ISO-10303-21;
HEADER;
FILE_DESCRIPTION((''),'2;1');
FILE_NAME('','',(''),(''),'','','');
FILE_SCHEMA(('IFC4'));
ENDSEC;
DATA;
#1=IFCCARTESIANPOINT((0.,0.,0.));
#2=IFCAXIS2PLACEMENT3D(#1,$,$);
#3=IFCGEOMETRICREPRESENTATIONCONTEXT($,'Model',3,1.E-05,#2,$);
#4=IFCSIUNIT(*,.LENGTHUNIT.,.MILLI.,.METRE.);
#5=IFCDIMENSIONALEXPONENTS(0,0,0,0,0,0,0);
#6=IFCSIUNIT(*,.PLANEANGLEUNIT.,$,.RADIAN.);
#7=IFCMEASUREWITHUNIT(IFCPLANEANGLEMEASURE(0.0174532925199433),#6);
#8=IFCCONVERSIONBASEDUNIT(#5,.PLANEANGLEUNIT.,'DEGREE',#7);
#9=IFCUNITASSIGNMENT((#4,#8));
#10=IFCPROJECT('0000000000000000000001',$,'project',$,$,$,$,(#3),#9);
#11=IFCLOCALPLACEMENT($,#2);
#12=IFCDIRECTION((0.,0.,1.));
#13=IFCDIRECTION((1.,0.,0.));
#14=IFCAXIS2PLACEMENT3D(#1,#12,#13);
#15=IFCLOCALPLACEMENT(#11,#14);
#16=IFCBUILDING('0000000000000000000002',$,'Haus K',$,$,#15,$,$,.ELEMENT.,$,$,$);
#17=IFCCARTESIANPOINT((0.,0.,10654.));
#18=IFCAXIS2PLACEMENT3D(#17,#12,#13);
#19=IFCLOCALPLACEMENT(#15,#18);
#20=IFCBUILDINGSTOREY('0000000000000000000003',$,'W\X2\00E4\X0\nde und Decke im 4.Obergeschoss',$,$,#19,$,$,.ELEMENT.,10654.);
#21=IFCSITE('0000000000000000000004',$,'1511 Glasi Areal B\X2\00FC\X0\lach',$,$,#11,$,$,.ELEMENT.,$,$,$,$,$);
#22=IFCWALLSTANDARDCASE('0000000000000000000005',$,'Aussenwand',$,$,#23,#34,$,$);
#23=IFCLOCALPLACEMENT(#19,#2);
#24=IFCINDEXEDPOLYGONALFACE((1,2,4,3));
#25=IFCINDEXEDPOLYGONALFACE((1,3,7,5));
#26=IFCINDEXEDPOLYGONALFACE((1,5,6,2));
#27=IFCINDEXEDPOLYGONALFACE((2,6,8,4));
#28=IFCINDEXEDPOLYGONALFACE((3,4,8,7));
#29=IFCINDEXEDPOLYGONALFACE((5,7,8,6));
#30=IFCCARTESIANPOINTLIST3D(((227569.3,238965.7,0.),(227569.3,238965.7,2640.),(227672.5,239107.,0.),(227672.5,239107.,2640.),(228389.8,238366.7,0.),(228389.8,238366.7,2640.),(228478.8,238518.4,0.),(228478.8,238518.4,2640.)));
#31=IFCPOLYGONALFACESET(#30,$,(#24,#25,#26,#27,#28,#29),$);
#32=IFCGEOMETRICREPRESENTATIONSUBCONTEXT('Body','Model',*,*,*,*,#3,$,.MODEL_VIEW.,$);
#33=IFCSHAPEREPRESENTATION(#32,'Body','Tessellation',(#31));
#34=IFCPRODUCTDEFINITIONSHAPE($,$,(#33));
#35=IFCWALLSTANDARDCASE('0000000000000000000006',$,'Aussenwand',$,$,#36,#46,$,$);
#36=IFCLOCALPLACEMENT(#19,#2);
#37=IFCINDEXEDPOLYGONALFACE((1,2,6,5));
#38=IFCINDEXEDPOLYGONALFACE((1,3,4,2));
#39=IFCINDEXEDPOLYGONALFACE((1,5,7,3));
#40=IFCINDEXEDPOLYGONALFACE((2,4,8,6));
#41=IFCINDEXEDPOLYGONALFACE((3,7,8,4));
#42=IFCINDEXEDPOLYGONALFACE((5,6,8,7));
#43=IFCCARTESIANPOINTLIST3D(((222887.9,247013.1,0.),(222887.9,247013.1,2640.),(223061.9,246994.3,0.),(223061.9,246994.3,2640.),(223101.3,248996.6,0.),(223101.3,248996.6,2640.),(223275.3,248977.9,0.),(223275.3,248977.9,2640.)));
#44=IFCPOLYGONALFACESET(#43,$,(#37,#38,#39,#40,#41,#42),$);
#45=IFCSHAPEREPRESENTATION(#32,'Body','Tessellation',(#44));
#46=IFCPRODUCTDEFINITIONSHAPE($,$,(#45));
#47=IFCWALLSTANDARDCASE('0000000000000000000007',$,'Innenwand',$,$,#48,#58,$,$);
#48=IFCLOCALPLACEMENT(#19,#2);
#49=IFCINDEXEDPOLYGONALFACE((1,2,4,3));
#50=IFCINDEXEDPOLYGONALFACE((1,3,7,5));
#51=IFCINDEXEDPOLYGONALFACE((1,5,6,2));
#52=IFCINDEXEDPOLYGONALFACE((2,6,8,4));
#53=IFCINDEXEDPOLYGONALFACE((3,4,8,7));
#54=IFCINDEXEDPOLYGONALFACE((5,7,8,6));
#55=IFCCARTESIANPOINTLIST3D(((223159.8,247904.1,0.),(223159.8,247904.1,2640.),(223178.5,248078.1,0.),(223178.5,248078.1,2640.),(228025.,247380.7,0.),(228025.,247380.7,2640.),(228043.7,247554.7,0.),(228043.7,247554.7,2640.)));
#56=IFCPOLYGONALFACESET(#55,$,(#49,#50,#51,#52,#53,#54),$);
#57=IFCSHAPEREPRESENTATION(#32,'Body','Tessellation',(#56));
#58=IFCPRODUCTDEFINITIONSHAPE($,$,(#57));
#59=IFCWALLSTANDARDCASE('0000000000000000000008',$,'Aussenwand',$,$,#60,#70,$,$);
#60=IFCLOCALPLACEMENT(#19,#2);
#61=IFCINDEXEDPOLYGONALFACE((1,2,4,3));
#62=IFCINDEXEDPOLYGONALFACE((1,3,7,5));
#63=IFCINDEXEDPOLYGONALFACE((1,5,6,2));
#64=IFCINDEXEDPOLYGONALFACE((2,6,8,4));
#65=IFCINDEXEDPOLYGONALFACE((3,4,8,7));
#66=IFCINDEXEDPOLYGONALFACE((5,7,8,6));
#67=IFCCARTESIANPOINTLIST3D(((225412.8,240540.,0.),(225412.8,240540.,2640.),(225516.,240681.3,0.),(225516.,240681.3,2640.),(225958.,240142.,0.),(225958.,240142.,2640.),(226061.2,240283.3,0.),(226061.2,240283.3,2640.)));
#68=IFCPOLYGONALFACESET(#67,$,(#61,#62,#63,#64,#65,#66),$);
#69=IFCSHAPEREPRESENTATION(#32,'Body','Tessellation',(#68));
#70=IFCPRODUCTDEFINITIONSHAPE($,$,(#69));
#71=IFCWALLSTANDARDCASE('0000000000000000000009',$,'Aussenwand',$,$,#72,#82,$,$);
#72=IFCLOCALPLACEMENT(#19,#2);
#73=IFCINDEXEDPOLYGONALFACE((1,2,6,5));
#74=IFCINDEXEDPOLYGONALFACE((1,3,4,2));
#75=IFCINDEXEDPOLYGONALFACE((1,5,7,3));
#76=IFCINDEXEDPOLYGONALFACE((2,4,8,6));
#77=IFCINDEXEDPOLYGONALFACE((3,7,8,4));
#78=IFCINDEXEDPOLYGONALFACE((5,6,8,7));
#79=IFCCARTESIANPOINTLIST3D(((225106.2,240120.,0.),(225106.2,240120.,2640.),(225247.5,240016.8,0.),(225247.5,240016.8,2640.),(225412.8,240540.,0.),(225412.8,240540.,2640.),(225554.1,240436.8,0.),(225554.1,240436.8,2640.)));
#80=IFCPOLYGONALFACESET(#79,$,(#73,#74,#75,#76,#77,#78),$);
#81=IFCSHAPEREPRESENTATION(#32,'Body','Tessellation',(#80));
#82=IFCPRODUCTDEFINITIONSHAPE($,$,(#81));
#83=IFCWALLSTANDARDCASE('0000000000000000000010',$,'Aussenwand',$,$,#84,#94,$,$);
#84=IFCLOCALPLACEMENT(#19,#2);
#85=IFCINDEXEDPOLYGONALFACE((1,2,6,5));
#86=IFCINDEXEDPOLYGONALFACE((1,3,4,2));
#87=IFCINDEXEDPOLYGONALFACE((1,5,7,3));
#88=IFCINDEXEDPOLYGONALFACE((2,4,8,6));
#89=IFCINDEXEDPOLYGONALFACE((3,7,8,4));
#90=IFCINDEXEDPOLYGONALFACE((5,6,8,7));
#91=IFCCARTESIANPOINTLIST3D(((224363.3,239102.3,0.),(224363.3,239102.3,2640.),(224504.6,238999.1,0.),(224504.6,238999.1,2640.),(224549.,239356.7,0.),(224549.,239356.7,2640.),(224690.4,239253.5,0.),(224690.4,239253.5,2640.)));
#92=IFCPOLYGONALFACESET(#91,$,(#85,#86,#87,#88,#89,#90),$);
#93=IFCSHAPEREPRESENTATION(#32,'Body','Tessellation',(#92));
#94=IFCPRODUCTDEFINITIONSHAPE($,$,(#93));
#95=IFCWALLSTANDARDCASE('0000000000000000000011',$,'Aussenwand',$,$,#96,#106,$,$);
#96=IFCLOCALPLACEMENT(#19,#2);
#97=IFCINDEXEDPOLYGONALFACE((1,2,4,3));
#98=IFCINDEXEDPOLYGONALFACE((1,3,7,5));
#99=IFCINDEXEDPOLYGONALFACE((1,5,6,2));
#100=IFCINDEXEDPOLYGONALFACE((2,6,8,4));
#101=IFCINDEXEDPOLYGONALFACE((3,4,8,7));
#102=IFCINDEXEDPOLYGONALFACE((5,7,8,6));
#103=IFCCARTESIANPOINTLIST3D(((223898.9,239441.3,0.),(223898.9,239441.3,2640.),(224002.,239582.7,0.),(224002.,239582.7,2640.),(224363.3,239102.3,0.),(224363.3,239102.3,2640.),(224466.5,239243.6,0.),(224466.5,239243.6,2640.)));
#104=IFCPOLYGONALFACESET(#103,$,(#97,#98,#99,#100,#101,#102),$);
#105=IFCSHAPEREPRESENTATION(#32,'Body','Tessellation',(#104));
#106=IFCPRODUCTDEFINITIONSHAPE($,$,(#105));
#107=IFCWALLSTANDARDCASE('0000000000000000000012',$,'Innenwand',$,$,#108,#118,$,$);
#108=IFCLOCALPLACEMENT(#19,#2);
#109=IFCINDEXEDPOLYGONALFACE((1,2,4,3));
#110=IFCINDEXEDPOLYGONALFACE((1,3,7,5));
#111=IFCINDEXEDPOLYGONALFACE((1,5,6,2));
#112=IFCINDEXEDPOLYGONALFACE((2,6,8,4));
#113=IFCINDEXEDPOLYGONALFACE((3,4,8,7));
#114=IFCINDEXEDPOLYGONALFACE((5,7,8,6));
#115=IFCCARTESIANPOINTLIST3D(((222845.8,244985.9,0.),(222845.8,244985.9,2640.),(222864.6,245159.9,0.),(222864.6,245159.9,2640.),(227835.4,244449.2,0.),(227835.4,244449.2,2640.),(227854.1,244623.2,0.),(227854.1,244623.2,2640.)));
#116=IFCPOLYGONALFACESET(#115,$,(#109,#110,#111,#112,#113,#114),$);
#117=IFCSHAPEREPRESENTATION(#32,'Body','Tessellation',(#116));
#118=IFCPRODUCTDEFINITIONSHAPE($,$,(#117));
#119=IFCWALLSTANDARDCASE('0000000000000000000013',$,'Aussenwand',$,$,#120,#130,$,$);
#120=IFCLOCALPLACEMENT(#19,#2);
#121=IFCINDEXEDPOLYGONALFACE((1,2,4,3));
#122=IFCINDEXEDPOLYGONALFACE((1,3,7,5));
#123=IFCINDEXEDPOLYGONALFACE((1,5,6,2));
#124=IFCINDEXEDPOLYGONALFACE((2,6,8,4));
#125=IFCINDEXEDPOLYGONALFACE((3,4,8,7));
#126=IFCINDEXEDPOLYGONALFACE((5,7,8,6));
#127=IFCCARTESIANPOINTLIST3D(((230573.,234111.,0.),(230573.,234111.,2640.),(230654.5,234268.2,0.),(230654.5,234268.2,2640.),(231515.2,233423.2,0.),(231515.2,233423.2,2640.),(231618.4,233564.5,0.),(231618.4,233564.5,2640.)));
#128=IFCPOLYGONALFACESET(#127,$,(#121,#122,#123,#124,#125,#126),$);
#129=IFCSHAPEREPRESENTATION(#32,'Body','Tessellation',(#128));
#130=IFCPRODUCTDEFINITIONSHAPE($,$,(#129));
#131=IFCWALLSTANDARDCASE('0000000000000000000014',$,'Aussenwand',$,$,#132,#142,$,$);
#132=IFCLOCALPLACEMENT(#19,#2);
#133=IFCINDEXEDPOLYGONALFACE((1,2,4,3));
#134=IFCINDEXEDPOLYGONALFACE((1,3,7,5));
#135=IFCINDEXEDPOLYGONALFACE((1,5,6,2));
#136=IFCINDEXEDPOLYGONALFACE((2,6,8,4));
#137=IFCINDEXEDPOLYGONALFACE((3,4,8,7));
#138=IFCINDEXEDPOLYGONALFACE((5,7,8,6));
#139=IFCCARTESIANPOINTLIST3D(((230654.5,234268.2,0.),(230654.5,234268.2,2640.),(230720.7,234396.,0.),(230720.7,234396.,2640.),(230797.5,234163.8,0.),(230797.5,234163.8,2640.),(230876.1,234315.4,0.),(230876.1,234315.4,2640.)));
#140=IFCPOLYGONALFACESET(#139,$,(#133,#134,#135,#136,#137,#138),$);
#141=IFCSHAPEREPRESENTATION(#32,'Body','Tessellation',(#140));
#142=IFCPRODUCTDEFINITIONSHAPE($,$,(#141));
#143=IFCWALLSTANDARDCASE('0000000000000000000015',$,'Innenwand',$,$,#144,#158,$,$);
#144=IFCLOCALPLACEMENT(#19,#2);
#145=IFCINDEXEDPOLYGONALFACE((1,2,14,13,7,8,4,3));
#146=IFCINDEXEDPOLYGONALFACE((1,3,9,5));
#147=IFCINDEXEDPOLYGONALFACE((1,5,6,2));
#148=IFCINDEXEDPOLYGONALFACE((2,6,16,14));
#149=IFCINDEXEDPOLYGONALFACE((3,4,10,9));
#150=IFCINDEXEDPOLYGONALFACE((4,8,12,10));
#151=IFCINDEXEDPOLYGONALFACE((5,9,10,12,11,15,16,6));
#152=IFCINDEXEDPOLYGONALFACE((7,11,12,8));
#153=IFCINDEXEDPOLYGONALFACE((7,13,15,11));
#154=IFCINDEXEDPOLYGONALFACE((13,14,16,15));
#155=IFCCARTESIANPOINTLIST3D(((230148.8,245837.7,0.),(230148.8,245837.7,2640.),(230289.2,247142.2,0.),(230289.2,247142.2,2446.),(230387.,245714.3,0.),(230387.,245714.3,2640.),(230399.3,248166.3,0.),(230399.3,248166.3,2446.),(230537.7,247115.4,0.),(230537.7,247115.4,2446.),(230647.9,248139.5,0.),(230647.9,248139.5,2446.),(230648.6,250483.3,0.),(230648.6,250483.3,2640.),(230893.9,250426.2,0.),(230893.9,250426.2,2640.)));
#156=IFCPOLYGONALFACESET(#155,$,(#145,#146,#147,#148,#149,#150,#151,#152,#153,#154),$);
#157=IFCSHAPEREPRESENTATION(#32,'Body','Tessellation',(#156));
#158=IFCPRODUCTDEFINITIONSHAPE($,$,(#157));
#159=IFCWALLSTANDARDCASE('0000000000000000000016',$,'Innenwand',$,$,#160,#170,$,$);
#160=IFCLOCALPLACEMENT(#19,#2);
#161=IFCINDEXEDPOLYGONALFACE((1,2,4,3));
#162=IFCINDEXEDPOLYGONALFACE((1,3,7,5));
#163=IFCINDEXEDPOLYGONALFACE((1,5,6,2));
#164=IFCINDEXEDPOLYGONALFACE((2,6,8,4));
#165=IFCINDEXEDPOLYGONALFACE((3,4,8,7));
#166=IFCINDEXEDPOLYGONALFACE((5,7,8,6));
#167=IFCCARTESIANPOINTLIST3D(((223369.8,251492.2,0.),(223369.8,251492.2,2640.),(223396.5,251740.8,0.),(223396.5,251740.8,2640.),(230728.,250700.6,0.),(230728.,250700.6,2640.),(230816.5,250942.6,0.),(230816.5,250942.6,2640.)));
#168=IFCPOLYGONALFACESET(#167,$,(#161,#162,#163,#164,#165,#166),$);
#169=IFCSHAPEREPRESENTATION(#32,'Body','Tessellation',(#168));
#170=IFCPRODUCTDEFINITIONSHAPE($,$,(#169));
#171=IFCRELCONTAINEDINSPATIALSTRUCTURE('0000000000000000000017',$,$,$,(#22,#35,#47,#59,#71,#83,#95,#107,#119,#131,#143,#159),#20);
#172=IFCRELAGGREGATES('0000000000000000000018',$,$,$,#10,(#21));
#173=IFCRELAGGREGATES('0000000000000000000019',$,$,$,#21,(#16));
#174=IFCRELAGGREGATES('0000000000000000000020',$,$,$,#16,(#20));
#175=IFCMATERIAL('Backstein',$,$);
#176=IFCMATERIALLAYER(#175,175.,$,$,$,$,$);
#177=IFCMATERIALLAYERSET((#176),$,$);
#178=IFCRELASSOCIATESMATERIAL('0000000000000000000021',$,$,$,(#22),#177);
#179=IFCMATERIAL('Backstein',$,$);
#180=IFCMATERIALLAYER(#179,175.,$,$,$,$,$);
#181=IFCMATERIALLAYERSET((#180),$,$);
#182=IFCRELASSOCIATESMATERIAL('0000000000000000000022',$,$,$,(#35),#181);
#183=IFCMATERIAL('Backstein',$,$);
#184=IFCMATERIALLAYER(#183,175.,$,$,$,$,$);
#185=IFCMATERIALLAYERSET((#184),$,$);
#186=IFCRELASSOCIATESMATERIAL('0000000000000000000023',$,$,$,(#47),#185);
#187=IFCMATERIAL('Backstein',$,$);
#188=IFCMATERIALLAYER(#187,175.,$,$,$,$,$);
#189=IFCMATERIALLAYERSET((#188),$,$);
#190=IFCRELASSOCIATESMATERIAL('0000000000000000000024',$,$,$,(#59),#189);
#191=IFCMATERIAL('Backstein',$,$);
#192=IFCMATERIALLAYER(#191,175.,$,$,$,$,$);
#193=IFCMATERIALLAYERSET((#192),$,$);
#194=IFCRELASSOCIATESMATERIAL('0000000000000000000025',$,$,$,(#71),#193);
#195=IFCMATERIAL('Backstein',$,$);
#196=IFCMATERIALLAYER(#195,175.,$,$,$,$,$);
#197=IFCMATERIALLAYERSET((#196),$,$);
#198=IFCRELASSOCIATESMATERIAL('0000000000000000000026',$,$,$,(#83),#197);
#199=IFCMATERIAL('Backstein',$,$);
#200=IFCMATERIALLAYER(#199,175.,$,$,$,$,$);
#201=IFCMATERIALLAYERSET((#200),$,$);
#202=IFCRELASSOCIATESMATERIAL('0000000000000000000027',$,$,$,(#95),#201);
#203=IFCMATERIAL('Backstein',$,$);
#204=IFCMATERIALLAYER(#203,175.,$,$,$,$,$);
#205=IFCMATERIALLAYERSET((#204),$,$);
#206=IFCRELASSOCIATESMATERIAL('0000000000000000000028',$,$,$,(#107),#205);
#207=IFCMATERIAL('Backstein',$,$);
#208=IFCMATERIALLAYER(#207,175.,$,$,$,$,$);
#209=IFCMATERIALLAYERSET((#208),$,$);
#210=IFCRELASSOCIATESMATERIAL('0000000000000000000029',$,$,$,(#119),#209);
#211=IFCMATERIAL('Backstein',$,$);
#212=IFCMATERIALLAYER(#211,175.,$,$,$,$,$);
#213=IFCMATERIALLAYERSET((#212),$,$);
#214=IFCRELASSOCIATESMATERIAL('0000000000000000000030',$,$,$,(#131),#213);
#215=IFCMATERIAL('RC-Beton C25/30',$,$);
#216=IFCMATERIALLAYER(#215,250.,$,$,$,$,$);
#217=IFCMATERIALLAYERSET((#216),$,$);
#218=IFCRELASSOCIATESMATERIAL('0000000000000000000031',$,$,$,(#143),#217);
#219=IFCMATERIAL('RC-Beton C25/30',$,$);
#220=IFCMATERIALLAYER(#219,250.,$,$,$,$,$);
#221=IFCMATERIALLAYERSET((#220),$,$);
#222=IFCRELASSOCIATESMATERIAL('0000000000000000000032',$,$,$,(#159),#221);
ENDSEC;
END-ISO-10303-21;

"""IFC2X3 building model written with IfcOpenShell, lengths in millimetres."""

from ifc_helpers import new_model, entity, si_unit, converted_unit, frame, frame_2d, origin, origin_with_axes, place, context, subcontext, project, spatial, polyline, rectangle, outline, extrude, material, layer, layer_set, layer_usage, element, save


model = new_model("IFC2X3")

# Units and contexts
model_context = context("Model", 3, precision=1e-05, world=origin())
body_context = subcontext(model_context, "Body", "Model", "MODEL_VIEW")
ifc_project = project(units=[si_unit("LENGTHUNIT", "METRE", prefix="MILLI"), converted_unit("PLANEANGLEUNIT", "DEGREE", entity("IfcPlaneAngleMeasure", 0.0174532925199433), si_unit("PLANEANGLEUNIT", "RADIAN"), dimensions=[0, 0, 0, 0, 0, 0, 0])], contexts=[model_context])

# Site, building, storey
site_placement = place(None, origin())
site = spatial("IfcSite", under=ifc_project, at=site_placement, Name="1511 Glasi Areal Bülach", CompositionType="ELEMENT")
building_placement = place(site_placement, origin_with_axes())
building = spatial("IfcBuilding", under=site, at=building_placement, Name="Haus K", CompositionType="ELEMENT")
storey_placement = place(building_placement, frame((0.0, 0.0, 10654.0), z_axis=(0.0, 0.0, 1.0), x_axis=(1.0, 0.0, 0.0)))
storey = spatial("IfcBuildingStorey", under=building, at=storey_placement, Name="Wände und Decke im 4.Obergeschoss", CompositionType="ELEMENT", Elevation=10654.0)

# Walls
ifc_material_1 = material(Name="Backstein")
ifc_layer_1 = layer(ifc_material_1, 175.0)
ifc_layer_set_1 = layer_set([ifc_layer_1])
ifc_layer_usage_1 = layer_usage(ifc_layer_set_1, "AXIS2", "POSITIVE", 0.0)
wall_1_placement = place(storey_placement, frame((227569.3, 238965.7, 0.0), z_axis=(0.0, 0.0, 1.0), x_axis=(0.807681, -0.589619, 0.0)))
element("IfcWallStandardCase", 1, at=wall_1_placement, inside=storey, material=ifc_layer_usage_1, Name="Aussenwand", context=body_context, shape_type="SweptSolid", body=[
    extrude(outline(polyline([(0.0, 0.0), (1015.8, 0.0), (998.3, 175.0), (0.0, 175.0), (0.0, 0.0)])), origin_with_axes(), (0.0, 0.0, 1.0), 2640.0),
])
ifc_material_2 = material(Name="Backstein")
ifc_layer_2 = layer(ifc_material_2, 175.0)
ifc_layer_set_2 = layer_set([ifc_layer_2])
ifc_layer_usage_2 = layer_usage(ifc_layer_set_2, "AXIS2", "POSITIVE", 0.0)
wall_2_placement = place(storey_placement, frame((223101.3, 248996.6, 0.0), z_axis=(0.0, 0.0, 1.0), x_axis=(-0.106958, -0.994264, 0.0)))
element("IfcWallStandardCase", 2, at=wall_2_placement, inside=storey, material=ifc_layer_usage_2, Name="Aussenwand", context=body_context, shape_type="SweptSolid", body=[
    extrude(rectangle(XDim=1995.0, YDim=175.0, at=frame_2d((997.5, 87.5), x_axis=(1.0, 0.0))), origin_with_axes(), (0.0, 0.0, 1.0), 2640.0),
])
ifc_material_3 = material(Name="Backstein")
ifc_layer_3 = layer(ifc_material_3, 175.0)
ifc_layer_set_3 = layer_set([ifc_layer_3])
ifc_layer_usage_3 = layer_usage(ifc_layer_set_3, "AXIS2", "POSITIVE", 0.0)
wall_3_placement = place(storey_placement, frame((223159.8, 247904.1, 0.0), z_axis=(0.0, 0.0, 1.0), x_axis=(0.994264, -0.106958, 0.0)))
element("IfcWallStandardCase", 3, at=wall_3_placement, inside=storey, material=ifc_layer_usage_3, Name="Innenwand", context=body_context, shape_type="SweptSolid", body=[
    extrude(rectangle(XDim=4893.3, YDim=175.0, at=frame_2d((2446.7, 87.5), x_axis=(1.0, 0.0))), origin_with_axes(), (0.0, 0.0, 1.0), 2640.0),
])
ifc_material_4 = material(Name="Backstein")
ifc_layer_4 = layer(ifc_material_4, 175.0)
ifc_layer_set_4 = layer_set([ifc_layer_4])
ifc_layer_usage_4 = layer_usage(ifc_layer_set_4, "AXIS2", "POSITIVE", 0.0)
wall_4_placement = place(storey_placement, frame((225412.8, 240540.0, 0.0), z_axis=(0.0, 0.0, 1.0), x_axis=(0.807681, -0.589619, 0.0)))
element("IfcWallStandardCase", 4, at=wall_4_placement, inside=storey, material=ifc_layer_usage_4, Name="Aussenwand", context=body_context, shape_type="SweptSolid", body=[
    extrude(rectangle(XDim=675.0, YDim=175.0, at=frame_2d((337.5, 87.5), x_axis=(1.0, 0.0))), origin_with_axes(), (0.0, 0.0, 1.0), 2640.0),
])
ifc_material_5 = material(Name="Backstein")
ifc_layer_5 = layer(ifc_material_5, 175.0)
ifc_layer_set_5 = layer_set([ifc_layer_5])
ifc_layer_usage_5 = layer_usage(ifc_layer_set_5, "AXIS2", "POSITIVE", 0.0)
wall_5_placement = place(storey_placement, frame((225247.5, 240016.8, 0.0), z_axis=(0.0, 0.0, 1.0), x_axis=(0.589619, 0.807681, 0.0)))
element("IfcWallStandardCase", 5, at=wall_5_placement, inside=storey, material=ifc_layer_usage_5, Name="Aussenwand", context=body_context, shape_type="SweptSolid", body=[
    extrude(rectangle(XDim=520.0, YDim=175.0, at=frame_2d((260.0, 87.5), x_axis=(1.0, 0.0))), origin_with_axes(), (0.0, 0.0, 1.0), 2640.0),
])
ifc_material_6 = material(Name="Backstein")
ifc_layer_6 = layer(ifc_material_6, 175.0)
ifc_layer_set_6 = layer_set([ifc_layer_6])
ifc_layer_usage_6 = layer_usage(ifc_layer_set_6, "AXIS2", "POSITIVE", 0.0)
wall_6_placement = place(storey_placement, frame((224504.6, 238999.1, 0.0), z_axis=(0.0, 0.0, 1.0), x_axis=(0.589619, 0.807681, 0.0)))
element("IfcWallStandardCase", 6, at=wall_6_placement, inside=storey, material=ifc_layer_usage_6, Name="Aussenwand", context=body_context, shape_type="SweptSolid", body=[
    extrude(rectangle(XDim=315.0, YDim=175.0, at=frame_2d((157.5, 87.5), x_axis=(1.0, 0.0))), origin_with_axes(), (0.0, 0.0, 1.0), 2640.0),
])
ifc_material_7 = material(Name="Backstein")
ifc_layer_7 = layer(ifc_material_7, 175.0)
ifc_layer_set_7 = layer_set([ifc_layer_7])
ifc_layer_usage_7 = layer_usage(ifc_layer_set_7, "AXIS2", "POSITIVE", 0.0)
wall_7_placement = place(storey_placement, frame((223898.9, 239441.3, 0.0), z_axis=(0.0, 0.0, 1.0), x_axis=(0.807681, -0.589619, 0.0)))
element("IfcWallStandardCase", 7, at=wall_7_placement, inside=storey, material=ifc_layer_usage_7, Name="Aussenwand", context=body_context, shape_type="SweptSolid", body=[
    extrude(rectangle(XDim=575.0, YDim=175.0, at=frame_2d((287.5, 87.5), x_axis=(1.0, 0.0))), origin_with_axes(), (0.0, 0.0, 1.0), 2640.0),
])
ifc_material_8 = material(Name="Backstein")
ifc_layer_8 = layer(ifc_material_8, 175.0)
ifc_layer_set_8 = layer_set([ifc_layer_8])
ifc_layer_usage_8 = layer_usage(ifc_layer_set_8, "AXIS2", "POSITIVE", 0.0)
wall_8_placement = place(storey_placement, frame((222845.8, 244985.9, 0.0), z_axis=(0.0, 0.0, 1.0), x_axis=(0.994264, -0.106958, 0.0)))
element("IfcWallStandardCase", 8, at=wall_8_placement, inside=storey, material=ifc_layer_usage_8, Name="Innenwand", context=body_context, shape_type="SweptSolid", body=[
    extrude(rectangle(XDim=5018.3, YDim=175.0, at=frame_2d((2509.2, 87.5), x_axis=(1.0, 0.0))), origin_with_axes(), (0.0, 0.0, 1.0), 2640.0),
])
ifc_material_9 = material(Name="Backstein")
ifc_layer_9 = layer(ifc_material_9, 175.0)
ifc_layer_set_9 = layer_set([ifc_layer_9])
ifc_layer_usage_9 = layer_usage(ifc_layer_set_9, "AXIS2", "POSITIVE", 0.0)
wall_9_placement = place(storey_placement, frame((230573.0, 234111.0, 0.0), z_axis=(0.0, 0.0, 1.0), x_axis=(0.807681, -0.589619, 0.0)))
element("IfcWallStandardCase", 9, at=wall_9_placement, inside=storey, material=ifc_layer_usage_9, Name="Aussenwand", context=body_context, shape_type="SweptSolid", body=[
    extrude(outline(polyline([(0.0, 0.0), (1166.6, 0.0), (1166.6, 175.0), (-26.9, 175.0), (0.0, 0.0)])), origin_with_axes(), (0.0, 0.0, 1.0), 2640.0),
])
ifc_material_10 = material(Name="Backstein")
ifc_layer_10 = layer(ifc_material_10, 175.0)
ifc_layer_set_10 = layer_set([ifc_layer_10])
ifc_layer_usage_10 = layer_usage(ifc_layer_set_10, "AXIS2", "POSITIVE", 0.0)
wall_10_placement = place(storey_placement, frame((230720.7, 234396.0, 0.0), z_axis=(0.0, 0.0, 1.0), x_axis=(-0.4602, -0.887815, 0.0)))
element("IfcWallStandardCase", 10, at=wall_10_placement, inside=storey, material=ifc_layer_usage_10, Name="Aussenwand", context=body_context, shape_type="SweptSolid", body=[
    extrude(outline(polyline([(0.0, 0.0), (143.9, 0.0), (170.8, 175.0), (0.0, 175.0), (0.0, 0.0)])), origin_with_axes(), (0.0, 0.0, 1.0), 2640.0),
])

# Wall, opening
ifc_material_11 = material(Name="RC-Beton C25/30")
ifc_layer_11 = layer(ifc_material_11, 250.0)
ifc_layer_set_11 = layer_set([ifc_layer_11])
ifc_layer_usage_11 = layer_usage(ifc_layer_set_11, "AXIS2", "POSITIVE", 0.0)
wall_11_placement = place(storey_placement, frame((230387.0, 245714.3, 0.0), z_axis=(0.0, 0.0, 1.0), x_axis=(0.106958, 0.994264, 0.0)))
wall_11 = element("IfcWallStandardCase", 11, at=wall_11_placement, inside=storey, material=ifc_layer_usage_11, Name="Innenwand", context=body_context, shape_type="SweptSolid", body=[
    extrude(outline(polyline([(0.0, 0.0), (4739.1, 0.0), (4769.7, 250.0), (97.3, 250.0), (0.0, 0.0)])), origin_with_axes(), (0.0, 0.0, 1.0), 2640.0),
])
opening_placement = place(wall_11_placement, frame((1409.2, 0.0, 0.0), z_axis=(0.0, 1.0, 0.0), x_axis=(0.0, 0.0, 1.0)))
element("IfcOpeningElement", 12, at=opening_placement, cuts=wall_11, ObjectType="Opening", context=body_context, shape_type="SweptSolid", body=[
    extrude(rectangle(XDim=2446.0, YDim=1030.0, at=frame_2d((1223.0, 515.0), x_axis=(1.0, 0.0))), origin_with_axes(), (0.0, 0.0, 1.0), 250.0),
])

# Wall
ifc_material_12 = material(Name="RC-Beton C25/30")
ifc_layer_12 = layer(ifc_material_12, 250.0)
ifc_layer_set_12 = layer_set([ifc_layer_12])
ifc_layer_usage_12 = layer_usage(ifc_layer_set_12, "AXIS2", "POSITIVE", 0.0)
wall_12_placement = place(storey_placement, frame((230816.5, 250942.6, 0.0), z_axis=(0.0, 0.0, 1.0), x_axis=(-0.994264, 0.106958, 0.0)))
element("IfcWallStandardCase", 13, at=wall_12_placement, inside=storey, material=ifc_layer_usage_12, Name="Innenwand", context=body_context, shape_type="SweptSolid", body=[
    extrude(outline(polyline([(0.0, 0.0), (7462.8, 0.0), (7462.8, 250.0), (62.1, 250.0), (0.0, 0.0)])), origin_with_axes(), (0.0, 0.0, 1.0), 2640.0),
])

save(model, "model.ifc")
